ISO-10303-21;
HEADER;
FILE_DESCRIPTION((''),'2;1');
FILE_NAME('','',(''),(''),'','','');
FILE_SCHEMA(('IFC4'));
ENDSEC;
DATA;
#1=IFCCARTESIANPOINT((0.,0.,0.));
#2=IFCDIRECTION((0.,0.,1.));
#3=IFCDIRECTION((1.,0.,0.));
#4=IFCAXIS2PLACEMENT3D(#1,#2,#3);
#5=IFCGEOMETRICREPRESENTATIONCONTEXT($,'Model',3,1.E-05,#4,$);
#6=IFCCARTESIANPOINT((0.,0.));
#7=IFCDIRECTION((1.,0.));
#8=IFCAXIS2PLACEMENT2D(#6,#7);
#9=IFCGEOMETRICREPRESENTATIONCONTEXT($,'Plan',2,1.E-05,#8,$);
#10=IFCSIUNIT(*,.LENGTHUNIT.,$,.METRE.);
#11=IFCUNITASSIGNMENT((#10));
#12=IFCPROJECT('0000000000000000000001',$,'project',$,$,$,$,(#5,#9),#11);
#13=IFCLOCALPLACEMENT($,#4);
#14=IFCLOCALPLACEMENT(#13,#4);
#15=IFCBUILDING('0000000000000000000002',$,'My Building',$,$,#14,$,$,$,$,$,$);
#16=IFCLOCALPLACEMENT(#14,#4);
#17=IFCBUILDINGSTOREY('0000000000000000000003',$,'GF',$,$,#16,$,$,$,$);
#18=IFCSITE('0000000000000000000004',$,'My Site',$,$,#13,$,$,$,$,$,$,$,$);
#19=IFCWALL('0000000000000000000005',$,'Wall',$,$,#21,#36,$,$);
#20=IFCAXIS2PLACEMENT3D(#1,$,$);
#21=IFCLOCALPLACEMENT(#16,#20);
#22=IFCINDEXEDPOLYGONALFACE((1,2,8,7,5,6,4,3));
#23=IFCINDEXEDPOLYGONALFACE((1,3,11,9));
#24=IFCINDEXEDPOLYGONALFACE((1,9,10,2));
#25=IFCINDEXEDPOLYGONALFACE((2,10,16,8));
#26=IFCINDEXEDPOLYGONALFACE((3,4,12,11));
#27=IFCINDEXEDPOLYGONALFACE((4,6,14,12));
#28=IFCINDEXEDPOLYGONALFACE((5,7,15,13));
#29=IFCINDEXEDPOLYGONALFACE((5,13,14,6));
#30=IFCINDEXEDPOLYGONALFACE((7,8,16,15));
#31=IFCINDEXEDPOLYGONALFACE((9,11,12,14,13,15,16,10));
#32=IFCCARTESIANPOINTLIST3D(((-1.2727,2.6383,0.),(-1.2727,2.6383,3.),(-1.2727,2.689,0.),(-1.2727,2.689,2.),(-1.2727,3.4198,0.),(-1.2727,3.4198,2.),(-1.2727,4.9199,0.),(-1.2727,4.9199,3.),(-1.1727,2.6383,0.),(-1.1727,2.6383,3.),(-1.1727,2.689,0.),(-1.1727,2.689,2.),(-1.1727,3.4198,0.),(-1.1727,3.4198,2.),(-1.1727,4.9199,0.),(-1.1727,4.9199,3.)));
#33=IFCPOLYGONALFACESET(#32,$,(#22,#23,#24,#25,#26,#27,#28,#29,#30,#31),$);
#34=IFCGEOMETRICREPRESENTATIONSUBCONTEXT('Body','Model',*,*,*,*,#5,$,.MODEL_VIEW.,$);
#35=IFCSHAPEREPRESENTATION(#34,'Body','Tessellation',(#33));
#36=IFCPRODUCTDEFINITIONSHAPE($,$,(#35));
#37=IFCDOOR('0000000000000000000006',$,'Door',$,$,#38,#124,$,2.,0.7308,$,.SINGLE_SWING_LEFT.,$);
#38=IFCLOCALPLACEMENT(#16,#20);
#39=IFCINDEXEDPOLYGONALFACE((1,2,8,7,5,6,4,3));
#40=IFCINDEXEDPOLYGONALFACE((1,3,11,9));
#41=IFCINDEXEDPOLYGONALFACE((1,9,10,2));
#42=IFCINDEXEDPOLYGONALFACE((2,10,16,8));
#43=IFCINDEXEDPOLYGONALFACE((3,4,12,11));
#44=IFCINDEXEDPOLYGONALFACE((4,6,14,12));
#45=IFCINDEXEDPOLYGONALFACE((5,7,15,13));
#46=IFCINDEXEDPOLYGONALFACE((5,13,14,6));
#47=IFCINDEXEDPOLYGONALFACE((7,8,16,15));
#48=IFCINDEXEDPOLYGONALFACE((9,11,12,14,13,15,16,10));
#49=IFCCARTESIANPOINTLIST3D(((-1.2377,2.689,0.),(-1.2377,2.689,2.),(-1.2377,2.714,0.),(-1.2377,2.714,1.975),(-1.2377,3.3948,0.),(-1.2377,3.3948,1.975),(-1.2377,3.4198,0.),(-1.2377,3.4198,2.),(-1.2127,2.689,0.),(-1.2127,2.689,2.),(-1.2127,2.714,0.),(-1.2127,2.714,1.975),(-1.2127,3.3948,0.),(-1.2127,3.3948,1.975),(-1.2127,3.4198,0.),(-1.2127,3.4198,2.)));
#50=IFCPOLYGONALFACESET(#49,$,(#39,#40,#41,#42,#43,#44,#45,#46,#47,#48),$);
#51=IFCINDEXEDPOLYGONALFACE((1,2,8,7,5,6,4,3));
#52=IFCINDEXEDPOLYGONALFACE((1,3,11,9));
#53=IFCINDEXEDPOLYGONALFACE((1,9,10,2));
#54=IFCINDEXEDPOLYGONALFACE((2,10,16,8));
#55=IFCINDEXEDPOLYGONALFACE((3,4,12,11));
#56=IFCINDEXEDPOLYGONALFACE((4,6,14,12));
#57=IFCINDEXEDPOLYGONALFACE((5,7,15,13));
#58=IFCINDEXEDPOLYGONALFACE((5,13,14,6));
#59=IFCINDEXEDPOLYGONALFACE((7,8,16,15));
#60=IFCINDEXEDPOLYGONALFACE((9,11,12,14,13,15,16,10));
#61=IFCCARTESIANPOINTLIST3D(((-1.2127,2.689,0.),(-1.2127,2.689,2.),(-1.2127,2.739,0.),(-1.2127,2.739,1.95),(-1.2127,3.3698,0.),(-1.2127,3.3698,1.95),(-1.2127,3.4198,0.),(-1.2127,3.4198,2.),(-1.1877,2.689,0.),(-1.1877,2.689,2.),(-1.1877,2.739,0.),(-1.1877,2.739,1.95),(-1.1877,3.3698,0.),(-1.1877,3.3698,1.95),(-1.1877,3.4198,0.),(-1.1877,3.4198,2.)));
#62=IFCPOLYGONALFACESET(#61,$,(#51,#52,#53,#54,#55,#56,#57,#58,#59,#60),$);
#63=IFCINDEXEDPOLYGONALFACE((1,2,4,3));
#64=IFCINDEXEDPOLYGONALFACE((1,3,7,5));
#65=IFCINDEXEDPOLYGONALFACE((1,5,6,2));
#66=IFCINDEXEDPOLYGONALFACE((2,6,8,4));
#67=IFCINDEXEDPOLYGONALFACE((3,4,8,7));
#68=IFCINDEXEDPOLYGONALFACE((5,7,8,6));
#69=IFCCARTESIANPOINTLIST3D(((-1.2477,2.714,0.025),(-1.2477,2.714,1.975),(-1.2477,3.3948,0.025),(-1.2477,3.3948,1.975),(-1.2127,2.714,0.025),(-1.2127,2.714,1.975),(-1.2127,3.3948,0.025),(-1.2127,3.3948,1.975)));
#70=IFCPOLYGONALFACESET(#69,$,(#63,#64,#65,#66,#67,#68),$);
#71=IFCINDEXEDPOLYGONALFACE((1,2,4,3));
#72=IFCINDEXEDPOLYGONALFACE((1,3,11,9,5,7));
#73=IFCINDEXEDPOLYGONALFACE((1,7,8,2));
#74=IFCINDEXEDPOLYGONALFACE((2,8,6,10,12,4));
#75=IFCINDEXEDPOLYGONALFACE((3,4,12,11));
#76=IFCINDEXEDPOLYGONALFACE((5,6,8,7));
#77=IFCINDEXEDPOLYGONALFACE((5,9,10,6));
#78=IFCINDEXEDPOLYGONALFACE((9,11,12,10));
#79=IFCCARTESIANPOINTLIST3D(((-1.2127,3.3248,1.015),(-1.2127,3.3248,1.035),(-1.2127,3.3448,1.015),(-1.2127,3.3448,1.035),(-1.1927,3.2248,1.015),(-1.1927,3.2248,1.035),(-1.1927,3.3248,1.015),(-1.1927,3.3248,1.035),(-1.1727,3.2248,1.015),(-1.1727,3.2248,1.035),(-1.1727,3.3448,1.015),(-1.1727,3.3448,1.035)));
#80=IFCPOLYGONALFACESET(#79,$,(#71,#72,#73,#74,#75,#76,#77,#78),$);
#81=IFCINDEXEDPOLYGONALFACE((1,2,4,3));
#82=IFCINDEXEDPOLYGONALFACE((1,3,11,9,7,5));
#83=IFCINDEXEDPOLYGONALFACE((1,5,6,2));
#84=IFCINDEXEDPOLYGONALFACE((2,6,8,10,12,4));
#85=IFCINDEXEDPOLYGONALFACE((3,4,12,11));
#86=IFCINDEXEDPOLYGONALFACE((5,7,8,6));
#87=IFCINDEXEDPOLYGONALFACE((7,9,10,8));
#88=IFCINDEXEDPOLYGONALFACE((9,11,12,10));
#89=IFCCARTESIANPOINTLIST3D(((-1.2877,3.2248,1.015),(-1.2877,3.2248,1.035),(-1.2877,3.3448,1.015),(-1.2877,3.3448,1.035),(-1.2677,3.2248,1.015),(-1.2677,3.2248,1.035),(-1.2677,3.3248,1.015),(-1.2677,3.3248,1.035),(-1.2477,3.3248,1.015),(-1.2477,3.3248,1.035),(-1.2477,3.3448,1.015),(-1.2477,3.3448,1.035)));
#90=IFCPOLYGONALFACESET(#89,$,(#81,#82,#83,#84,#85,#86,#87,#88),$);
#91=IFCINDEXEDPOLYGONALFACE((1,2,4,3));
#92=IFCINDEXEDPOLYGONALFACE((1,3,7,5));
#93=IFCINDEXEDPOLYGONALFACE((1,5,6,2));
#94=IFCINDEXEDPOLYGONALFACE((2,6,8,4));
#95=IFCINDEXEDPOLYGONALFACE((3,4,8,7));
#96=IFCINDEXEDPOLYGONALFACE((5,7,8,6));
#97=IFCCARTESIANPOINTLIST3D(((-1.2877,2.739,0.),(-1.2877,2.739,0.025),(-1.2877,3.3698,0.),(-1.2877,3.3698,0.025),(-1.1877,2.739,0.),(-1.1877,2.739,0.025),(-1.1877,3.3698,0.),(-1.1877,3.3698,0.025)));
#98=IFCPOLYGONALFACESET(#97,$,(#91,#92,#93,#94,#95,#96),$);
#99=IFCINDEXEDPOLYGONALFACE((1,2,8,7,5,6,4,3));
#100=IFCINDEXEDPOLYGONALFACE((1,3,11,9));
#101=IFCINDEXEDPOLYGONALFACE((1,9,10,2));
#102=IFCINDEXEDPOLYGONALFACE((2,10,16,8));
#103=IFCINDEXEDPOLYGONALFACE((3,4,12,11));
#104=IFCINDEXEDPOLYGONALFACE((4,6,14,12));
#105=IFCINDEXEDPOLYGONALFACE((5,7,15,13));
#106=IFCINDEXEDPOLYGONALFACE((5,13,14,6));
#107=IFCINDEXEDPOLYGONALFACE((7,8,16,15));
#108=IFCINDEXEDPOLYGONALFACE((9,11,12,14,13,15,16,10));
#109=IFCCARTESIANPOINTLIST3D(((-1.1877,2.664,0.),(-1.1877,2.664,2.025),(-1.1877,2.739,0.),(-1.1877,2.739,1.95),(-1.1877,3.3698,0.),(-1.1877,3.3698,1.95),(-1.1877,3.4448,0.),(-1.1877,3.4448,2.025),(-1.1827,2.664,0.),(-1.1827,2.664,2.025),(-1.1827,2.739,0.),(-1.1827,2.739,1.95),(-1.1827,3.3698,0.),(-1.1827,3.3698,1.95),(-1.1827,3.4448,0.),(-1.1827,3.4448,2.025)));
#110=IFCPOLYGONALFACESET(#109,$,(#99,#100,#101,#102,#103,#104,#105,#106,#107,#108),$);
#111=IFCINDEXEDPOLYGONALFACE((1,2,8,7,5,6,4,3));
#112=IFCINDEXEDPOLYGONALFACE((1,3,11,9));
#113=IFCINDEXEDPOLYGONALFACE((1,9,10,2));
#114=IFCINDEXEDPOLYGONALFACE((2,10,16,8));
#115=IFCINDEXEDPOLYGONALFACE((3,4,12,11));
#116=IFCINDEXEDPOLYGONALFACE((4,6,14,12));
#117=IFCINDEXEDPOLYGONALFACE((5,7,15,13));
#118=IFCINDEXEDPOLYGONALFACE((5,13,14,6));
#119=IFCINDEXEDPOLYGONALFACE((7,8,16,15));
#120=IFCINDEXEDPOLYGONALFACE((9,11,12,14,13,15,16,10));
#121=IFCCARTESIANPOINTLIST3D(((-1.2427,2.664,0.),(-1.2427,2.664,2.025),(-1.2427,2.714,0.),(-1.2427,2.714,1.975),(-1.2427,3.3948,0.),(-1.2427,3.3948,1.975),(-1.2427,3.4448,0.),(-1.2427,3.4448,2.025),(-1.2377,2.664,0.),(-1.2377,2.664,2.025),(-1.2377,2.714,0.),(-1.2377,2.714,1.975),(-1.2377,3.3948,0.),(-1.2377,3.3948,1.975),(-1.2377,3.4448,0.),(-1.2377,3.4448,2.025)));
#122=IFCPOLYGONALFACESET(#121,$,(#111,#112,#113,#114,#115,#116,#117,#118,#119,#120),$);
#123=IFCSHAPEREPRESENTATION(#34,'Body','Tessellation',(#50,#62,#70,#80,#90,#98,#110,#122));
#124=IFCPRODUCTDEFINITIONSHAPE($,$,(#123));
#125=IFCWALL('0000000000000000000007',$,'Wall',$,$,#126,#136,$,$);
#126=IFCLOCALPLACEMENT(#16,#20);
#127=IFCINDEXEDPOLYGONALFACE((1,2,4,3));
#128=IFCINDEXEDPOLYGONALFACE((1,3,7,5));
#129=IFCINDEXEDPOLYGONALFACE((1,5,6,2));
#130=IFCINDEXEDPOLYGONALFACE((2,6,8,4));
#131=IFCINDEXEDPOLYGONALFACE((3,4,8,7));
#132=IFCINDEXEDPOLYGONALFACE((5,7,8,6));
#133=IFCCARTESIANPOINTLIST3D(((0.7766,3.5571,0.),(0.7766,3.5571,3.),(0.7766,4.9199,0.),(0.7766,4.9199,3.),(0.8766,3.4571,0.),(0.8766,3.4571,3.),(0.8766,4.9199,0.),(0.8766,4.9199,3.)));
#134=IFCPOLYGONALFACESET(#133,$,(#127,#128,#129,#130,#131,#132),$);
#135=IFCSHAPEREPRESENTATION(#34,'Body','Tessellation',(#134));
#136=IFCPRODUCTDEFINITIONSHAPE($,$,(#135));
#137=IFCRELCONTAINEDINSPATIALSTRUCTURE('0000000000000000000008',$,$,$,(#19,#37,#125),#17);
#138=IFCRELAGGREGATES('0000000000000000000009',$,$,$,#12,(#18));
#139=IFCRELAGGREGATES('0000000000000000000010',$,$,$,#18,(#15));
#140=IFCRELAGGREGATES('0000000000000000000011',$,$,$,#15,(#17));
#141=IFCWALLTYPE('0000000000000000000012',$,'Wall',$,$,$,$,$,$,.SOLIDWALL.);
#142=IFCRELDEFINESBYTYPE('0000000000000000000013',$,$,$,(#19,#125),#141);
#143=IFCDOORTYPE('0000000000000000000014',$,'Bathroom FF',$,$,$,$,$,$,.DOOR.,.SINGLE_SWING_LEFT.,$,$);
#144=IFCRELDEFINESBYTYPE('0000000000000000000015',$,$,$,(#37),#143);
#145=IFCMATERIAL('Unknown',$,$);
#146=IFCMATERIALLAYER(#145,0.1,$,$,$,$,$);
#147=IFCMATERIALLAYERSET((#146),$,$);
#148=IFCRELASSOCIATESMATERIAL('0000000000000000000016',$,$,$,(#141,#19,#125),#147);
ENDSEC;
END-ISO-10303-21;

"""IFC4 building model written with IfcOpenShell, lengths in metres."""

from ifc_helpers import new_model, entity, si_unit, frame, origin_with_axes, origin_2d_with_axis, place, context, subcontext, project, spatial, line, indexed_curve, outline, extrude, shape, source, transform, mapped, material, layer, layer_set, layer_usage, type_object, type_shapes, element, fill, save


model = new_model("IFC4")

# Units and contexts
model_context = context("Model", 3, precision=1e-05, world=origin_with_axes())
plan_context = context("Plan", 2, precision=1e-05, world=origin_2d_with_axis())
body_context_1 = subcontext(model_context, "Body", "Model", "MODEL_VIEW")
body_context_2 = subcontext(plan_context, "Body", "Plan", "PLAN_VIEW")
ifc_project = project(units=[si_unit("LENGTHUNIT", "METRE")], contexts=[model_context, plan_context])

# Site, building, storey
site_placement = place(None, origin_with_axes())
site = spatial("IfcSite", under=ifc_project, at=site_placement, Name="My Site")
building_placement = place(site_placement, origin_with_axes())
building = spatial("IfcBuilding", under=site, at=building_placement, Name="My Building")
storey_placement = place(building_placement, origin_with_axes())
storey = spatial("IfcBuildingStorey", under=building, at=storey_placement, Name="GF")

# Shared definitions
ifc_material = material(Name="Unknown")

# Shared definitions
ifc_layer_1 = layer(ifc_material, 0.1)
ifc_layer_set_1 = layer_set([ifc_layer_1])
wall_type = type_object("IfcWallType", Name="Wall", PredefinedType="SOLIDWALL", material=ifc_layer_set_1)

# Wall, opening, door
ifc_layer_usage_1 = layer_usage(ifc_layer_set_1, "AXIS2", "POSITIVE", 0.0)
wall_1_placement = place(storey_placement, frame((-1.1727, 2.6383, 0.0), z_axis=(0.0, 0.0, 1.0), x_axis=(0.0, 1.0, 0.0)))
wall_1 = element("IfcWall", 1, at=wall_1_placement, inside=storey, type_object=wall_type, material=ifc_layer_usage_1, Name="Wall", context=body_context_1, shape_type="SweptSolid", body=[
    extrude(outline(indexed_curve([(0.0, 0.0), (0.0, 0.1), (2.2816, 0.1), (2.2816, 0.0)], segments=[line(1, 2, 3, 4, 1)])), origin_with_axes(), (0.0, 0.0, 1.0), 3.0),
])
shared_shape_1 = source(origin_with_axes(), body_context_1, "Body", "SweptSolid", [
    extrude(outline(indexed_curve([(0.0, 0.0), (0.7308, 0.0), (0.7308, 2.0), (0.0, 2.0)], segments=[line(1, 2, 3, 4, 1)])), frame((0.0, -0.6, 0.0), z_axis=(0.0, -1.0, 0.0), x_axis=(1.0, 0.0, 0.0)), (0.0, 0.0, -1.0), 1.2),
])
opening_1_placement = place(wall_1_placement, frame((0.0507, 0.015, 0.0), z_axis=(0.0, 0.0, 1.0), x_axis=(1.0, 0.0, 0.0)))
opening_1 = element("IfcOpeningElement", 2, at=opening_1_placement, cuts=wall_1, PredefinedType="OPENING", context=body_context_1, shape_type="MappedRepresentation", body=[
    mapped(shared_shape_1, transform((0.0, 0.0, 0.0), x_axis=(1.0, 0.0, 0.0), y_axis=(0.0, 1.0, 0.0), z_axis=(0.0, 0.0, 1.0), scale=1.0)),
])
door_type_1 = type_object("IfcDoorType", Name="Bathroom FF", OperationType="SINGLE_SWING_LEFT", PredefinedType="DOOR")
shared_shape_2 = source(origin_with_axes(), body_context_1, "Body", "SweptSolid", [
    extrude(outline(indexed_curve([(0.0, 0.0), (0.0, 2.0), (0.7308, 2.0), (0.7308, 0.0), (0.7058, 0.0), (0.7058, 1.975), (0.025, 1.975), (0.025, 0.0)], segments=[line(1, 2, 3, 4, 5, 6, 7, 8, 1)])), frame((0.0, 0.025, 0.0), z_axis=(0.0, -1.0, 0.0), x_axis=(1.0, 0.0, 0.0)), (0.0, 0.0, -1.0), 0.025),
    extrude(outline(indexed_curve([(0.0, 0.0), (0.0, 2.0), (0.7308, 2.0), (0.7308, 0.0), (0.6808, 0.0), (0.6808, 1.95), (0.05, 1.95), (0.05, 0.0)], segments=[line(1, 2, 3, 4, 5, 6, 7, 8, 1)])), frame((0.0, 0.0, 0.0), z_axis=(0.0, -1.0, 0.0), x_axis=(1.0, 0.0, 0.0)), (0.0, 0.0, -1.0), 0.025),
    extrude(outline(indexed_curve([(0.0, 0.0), (0.6808, 0.0), (0.6808, 0.035), (0.0, 0.035)], segments=[line(1, 2, 3, 4, 1)])), frame((0.025, 0.025, 0.025), z_axis=(0.0, 0.0, 1.0), x_axis=(1.0, 0.0, 0.0)), (0.0, 0.0, 1.0), 1.95),
    extrude(outline(indexed_curve([(0.0, 0.0), (0.0, -0.04), (-0.12, -0.04), (-0.12, -0.02), (-0.02, -0.02), (-0.02, 0.0)], segments=[line(1, 2, 3, 4, 5, 6, 1)])), frame((0.6558, 0.025, 1.015), z_axis=(0.0, 0.0, 1.0), x_axis=(1.0, 0.0, 0.0)), (0.0, 0.0, 1.0), 0.02),
    extrude(outline(indexed_curve([(0.0, 0.0), (0.0, 0.04), (-0.12, 0.04), (-0.12, 0.02), (-0.02, 0.02), (-0.02, 0.0)], segments=[line(1, 2, 3, 4, 5, 6, 1)])), frame((0.6558, 0.06, 1.015), z_axis=(0.0, 0.0, 1.0), x_axis=(1.0, 0.0, 0.0)), (0.0, 0.0, 1.0), 0.02),
    extrude(outline(indexed_curve([(0.0, 0.0), (0.6308, 0.0), (0.6308, 0.1), (0.0, 0.1)], segments=[line(1, 2, 3, 4, 1)])), frame((0.05, 0.0, 0.0), z_axis=(0.0, 0.0, 1.0), x_axis=(1.0, 0.0, 0.0)), (0.0, 0.0, 1.0), 0.025),
    extrude(outline(indexed_curve([(0.0, 0.0), (0.0, 2.025), (0.7808, 2.025), (0.7808, 0.0), (0.7058, 0.0), (0.7058, 1.95), (0.075, 1.95), (0.075, 0.0)], segments=[line(1, 2, 3, 4, 5, 6, 7, 8, 1)])), frame((-0.025, -0.005, 0.0), z_axis=(0.0, -1.0, 0.0), x_axis=(1.0, 0.0, 0.0)), (0.0, 0.0, -1.0), 0.005),
    extrude(outline(indexed_curve([(0.0, 0.0), (0.0, 2.025), (0.7808, 2.025), (0.7808, 0.0), (0.7308, 0.0), (0.7308, 1.975), (0.05, 1.975), (0.05, 0.0)], segments=[line(1, 2, 3, 4, 5, 6, 7, 8, 1)])), frame((-0.025, 0.05, 0.0), z_axis=(0.0, -1.0, 0.0), x_axis=(1.0, 0.0, 0.0)), (0.0, 0.0, -1.0), 0.005),
])
shared_shape_3 = source(origin_with_axes(), body_context_2, "Body", "Curve2D", [
    entity("IfcIndexedPolyCurve", entity("IfcCartesianPointList2D", [[0.0, 0.0], [0.0, 0.05], [0.025, 0.05], [0.025, 0.025], [0.05, 0.025], [0.05, 0.0]]), [entity("IfcLineIndex", [1, 2, 3, 4, 5, 6, 1])]),
    entity("IfcIndexedPolyCurve", entity("IfcCartesianPointList2D", [[0.7308, 0.0], [0.7308, 0.05], [0.7058, 0.05], [0.7058, 0.025], [0.6808, 0.025], [0.6808, 0.0]]), [entity("IfcLineIndex", [1, 2, 3, 4, 5, 6, 1])]),
    entity("IfcTrimmedCurve", entity("IfcEllipse", entity("IfcAxis2Placement2D", entity("IfcCartesianPoint", [0.06, 0.05]), entity("IfcDirection", [1.0, 0.0])), 0.6458, 0.6808), [entity("IfcCartesianPoint", [0.7058, 0.05])], [entity("IfcCartesianPoint", [0.06, 0.7308])], True, "CARTESIAN"),
    entity("IfcIndexedPolyCurve", entity("IfcCartesianPointList2D", [[0.025, 0.05], [0.06, 0.05], [0.06, 0.7308], [0.025, 0.7308]]), [entity("IfcLineIndex", [1, 2, 3, 4, 1])]),
])
type_shapes(door_type_1, [shared_shape_2, shared_shape_3])
door_1_placement = place(opening_1_placement, frame((0.0, 0.0, 0.0), z_axis=(0.0, 0.0, 1.0), x_axis=(1.0, 0.0, 0.0)))
door_1 = element("IfcDoor", 3, at=door_1_placement, inside=storey, type_object=door_type_1, Name="Door", OperationType="SINGLE_SWING_LEFT", OverallHeight=2.0, OverallWidth=0.7308, shapes=[
    shape(body_context_1, "Body", "MappedRepresentation", [mapped(shared_shape_2, transform((0.0, 0.0, 0.0), x_axis=(1.0, 0.0, 0.0), y_axis=(0.0, 1.0, 0.0), z_axis=(0.0, 0.0, 1.0), scale=1.0))]),
    shape(body_context_2, "Body", "MappedRepresentation", [mapped(shared_shape_3, transform((0.0, 0.0, 0.0), x_axis=(1.0, 0.0, 0.0), y_axis=(0.0, 1.0, 0.0), z_axis=(0.0, 0.0, 1.0), scale=1.0))]),
])
fill(opening_1, door_1)

# Wall
ifc_layer_usage_2 = layer_usage(ifc_layer_set_1, "AXIS2", "POSITIVE", 0.0)
wall_2_placement = place(storey_placement, frame((0.7766, 5.0199, 0.0), z_axis=(0.0, 0.0, 1.0), x_axis=(0.0, -1.0, 0.0)))
element("IfcWall", 4, at=wall_2_placement, inside=storey, type_object=wall_type, material=ifc_layer_usage_2, Name="Wall", context=body_context_1, shape_type="SweptSolid", body=[
    extrude(outline(indexed_curve([(0.1, 0.0), (0.1, 0.1), (1.5628, 0.1), (1.4628, 0.0)], segments=[line(1, 2, 3, 4, 1)])), origin_with_axes(), (0.0, 0.0, 1.0), 3.0),
])

save(model, "model.ifc")
